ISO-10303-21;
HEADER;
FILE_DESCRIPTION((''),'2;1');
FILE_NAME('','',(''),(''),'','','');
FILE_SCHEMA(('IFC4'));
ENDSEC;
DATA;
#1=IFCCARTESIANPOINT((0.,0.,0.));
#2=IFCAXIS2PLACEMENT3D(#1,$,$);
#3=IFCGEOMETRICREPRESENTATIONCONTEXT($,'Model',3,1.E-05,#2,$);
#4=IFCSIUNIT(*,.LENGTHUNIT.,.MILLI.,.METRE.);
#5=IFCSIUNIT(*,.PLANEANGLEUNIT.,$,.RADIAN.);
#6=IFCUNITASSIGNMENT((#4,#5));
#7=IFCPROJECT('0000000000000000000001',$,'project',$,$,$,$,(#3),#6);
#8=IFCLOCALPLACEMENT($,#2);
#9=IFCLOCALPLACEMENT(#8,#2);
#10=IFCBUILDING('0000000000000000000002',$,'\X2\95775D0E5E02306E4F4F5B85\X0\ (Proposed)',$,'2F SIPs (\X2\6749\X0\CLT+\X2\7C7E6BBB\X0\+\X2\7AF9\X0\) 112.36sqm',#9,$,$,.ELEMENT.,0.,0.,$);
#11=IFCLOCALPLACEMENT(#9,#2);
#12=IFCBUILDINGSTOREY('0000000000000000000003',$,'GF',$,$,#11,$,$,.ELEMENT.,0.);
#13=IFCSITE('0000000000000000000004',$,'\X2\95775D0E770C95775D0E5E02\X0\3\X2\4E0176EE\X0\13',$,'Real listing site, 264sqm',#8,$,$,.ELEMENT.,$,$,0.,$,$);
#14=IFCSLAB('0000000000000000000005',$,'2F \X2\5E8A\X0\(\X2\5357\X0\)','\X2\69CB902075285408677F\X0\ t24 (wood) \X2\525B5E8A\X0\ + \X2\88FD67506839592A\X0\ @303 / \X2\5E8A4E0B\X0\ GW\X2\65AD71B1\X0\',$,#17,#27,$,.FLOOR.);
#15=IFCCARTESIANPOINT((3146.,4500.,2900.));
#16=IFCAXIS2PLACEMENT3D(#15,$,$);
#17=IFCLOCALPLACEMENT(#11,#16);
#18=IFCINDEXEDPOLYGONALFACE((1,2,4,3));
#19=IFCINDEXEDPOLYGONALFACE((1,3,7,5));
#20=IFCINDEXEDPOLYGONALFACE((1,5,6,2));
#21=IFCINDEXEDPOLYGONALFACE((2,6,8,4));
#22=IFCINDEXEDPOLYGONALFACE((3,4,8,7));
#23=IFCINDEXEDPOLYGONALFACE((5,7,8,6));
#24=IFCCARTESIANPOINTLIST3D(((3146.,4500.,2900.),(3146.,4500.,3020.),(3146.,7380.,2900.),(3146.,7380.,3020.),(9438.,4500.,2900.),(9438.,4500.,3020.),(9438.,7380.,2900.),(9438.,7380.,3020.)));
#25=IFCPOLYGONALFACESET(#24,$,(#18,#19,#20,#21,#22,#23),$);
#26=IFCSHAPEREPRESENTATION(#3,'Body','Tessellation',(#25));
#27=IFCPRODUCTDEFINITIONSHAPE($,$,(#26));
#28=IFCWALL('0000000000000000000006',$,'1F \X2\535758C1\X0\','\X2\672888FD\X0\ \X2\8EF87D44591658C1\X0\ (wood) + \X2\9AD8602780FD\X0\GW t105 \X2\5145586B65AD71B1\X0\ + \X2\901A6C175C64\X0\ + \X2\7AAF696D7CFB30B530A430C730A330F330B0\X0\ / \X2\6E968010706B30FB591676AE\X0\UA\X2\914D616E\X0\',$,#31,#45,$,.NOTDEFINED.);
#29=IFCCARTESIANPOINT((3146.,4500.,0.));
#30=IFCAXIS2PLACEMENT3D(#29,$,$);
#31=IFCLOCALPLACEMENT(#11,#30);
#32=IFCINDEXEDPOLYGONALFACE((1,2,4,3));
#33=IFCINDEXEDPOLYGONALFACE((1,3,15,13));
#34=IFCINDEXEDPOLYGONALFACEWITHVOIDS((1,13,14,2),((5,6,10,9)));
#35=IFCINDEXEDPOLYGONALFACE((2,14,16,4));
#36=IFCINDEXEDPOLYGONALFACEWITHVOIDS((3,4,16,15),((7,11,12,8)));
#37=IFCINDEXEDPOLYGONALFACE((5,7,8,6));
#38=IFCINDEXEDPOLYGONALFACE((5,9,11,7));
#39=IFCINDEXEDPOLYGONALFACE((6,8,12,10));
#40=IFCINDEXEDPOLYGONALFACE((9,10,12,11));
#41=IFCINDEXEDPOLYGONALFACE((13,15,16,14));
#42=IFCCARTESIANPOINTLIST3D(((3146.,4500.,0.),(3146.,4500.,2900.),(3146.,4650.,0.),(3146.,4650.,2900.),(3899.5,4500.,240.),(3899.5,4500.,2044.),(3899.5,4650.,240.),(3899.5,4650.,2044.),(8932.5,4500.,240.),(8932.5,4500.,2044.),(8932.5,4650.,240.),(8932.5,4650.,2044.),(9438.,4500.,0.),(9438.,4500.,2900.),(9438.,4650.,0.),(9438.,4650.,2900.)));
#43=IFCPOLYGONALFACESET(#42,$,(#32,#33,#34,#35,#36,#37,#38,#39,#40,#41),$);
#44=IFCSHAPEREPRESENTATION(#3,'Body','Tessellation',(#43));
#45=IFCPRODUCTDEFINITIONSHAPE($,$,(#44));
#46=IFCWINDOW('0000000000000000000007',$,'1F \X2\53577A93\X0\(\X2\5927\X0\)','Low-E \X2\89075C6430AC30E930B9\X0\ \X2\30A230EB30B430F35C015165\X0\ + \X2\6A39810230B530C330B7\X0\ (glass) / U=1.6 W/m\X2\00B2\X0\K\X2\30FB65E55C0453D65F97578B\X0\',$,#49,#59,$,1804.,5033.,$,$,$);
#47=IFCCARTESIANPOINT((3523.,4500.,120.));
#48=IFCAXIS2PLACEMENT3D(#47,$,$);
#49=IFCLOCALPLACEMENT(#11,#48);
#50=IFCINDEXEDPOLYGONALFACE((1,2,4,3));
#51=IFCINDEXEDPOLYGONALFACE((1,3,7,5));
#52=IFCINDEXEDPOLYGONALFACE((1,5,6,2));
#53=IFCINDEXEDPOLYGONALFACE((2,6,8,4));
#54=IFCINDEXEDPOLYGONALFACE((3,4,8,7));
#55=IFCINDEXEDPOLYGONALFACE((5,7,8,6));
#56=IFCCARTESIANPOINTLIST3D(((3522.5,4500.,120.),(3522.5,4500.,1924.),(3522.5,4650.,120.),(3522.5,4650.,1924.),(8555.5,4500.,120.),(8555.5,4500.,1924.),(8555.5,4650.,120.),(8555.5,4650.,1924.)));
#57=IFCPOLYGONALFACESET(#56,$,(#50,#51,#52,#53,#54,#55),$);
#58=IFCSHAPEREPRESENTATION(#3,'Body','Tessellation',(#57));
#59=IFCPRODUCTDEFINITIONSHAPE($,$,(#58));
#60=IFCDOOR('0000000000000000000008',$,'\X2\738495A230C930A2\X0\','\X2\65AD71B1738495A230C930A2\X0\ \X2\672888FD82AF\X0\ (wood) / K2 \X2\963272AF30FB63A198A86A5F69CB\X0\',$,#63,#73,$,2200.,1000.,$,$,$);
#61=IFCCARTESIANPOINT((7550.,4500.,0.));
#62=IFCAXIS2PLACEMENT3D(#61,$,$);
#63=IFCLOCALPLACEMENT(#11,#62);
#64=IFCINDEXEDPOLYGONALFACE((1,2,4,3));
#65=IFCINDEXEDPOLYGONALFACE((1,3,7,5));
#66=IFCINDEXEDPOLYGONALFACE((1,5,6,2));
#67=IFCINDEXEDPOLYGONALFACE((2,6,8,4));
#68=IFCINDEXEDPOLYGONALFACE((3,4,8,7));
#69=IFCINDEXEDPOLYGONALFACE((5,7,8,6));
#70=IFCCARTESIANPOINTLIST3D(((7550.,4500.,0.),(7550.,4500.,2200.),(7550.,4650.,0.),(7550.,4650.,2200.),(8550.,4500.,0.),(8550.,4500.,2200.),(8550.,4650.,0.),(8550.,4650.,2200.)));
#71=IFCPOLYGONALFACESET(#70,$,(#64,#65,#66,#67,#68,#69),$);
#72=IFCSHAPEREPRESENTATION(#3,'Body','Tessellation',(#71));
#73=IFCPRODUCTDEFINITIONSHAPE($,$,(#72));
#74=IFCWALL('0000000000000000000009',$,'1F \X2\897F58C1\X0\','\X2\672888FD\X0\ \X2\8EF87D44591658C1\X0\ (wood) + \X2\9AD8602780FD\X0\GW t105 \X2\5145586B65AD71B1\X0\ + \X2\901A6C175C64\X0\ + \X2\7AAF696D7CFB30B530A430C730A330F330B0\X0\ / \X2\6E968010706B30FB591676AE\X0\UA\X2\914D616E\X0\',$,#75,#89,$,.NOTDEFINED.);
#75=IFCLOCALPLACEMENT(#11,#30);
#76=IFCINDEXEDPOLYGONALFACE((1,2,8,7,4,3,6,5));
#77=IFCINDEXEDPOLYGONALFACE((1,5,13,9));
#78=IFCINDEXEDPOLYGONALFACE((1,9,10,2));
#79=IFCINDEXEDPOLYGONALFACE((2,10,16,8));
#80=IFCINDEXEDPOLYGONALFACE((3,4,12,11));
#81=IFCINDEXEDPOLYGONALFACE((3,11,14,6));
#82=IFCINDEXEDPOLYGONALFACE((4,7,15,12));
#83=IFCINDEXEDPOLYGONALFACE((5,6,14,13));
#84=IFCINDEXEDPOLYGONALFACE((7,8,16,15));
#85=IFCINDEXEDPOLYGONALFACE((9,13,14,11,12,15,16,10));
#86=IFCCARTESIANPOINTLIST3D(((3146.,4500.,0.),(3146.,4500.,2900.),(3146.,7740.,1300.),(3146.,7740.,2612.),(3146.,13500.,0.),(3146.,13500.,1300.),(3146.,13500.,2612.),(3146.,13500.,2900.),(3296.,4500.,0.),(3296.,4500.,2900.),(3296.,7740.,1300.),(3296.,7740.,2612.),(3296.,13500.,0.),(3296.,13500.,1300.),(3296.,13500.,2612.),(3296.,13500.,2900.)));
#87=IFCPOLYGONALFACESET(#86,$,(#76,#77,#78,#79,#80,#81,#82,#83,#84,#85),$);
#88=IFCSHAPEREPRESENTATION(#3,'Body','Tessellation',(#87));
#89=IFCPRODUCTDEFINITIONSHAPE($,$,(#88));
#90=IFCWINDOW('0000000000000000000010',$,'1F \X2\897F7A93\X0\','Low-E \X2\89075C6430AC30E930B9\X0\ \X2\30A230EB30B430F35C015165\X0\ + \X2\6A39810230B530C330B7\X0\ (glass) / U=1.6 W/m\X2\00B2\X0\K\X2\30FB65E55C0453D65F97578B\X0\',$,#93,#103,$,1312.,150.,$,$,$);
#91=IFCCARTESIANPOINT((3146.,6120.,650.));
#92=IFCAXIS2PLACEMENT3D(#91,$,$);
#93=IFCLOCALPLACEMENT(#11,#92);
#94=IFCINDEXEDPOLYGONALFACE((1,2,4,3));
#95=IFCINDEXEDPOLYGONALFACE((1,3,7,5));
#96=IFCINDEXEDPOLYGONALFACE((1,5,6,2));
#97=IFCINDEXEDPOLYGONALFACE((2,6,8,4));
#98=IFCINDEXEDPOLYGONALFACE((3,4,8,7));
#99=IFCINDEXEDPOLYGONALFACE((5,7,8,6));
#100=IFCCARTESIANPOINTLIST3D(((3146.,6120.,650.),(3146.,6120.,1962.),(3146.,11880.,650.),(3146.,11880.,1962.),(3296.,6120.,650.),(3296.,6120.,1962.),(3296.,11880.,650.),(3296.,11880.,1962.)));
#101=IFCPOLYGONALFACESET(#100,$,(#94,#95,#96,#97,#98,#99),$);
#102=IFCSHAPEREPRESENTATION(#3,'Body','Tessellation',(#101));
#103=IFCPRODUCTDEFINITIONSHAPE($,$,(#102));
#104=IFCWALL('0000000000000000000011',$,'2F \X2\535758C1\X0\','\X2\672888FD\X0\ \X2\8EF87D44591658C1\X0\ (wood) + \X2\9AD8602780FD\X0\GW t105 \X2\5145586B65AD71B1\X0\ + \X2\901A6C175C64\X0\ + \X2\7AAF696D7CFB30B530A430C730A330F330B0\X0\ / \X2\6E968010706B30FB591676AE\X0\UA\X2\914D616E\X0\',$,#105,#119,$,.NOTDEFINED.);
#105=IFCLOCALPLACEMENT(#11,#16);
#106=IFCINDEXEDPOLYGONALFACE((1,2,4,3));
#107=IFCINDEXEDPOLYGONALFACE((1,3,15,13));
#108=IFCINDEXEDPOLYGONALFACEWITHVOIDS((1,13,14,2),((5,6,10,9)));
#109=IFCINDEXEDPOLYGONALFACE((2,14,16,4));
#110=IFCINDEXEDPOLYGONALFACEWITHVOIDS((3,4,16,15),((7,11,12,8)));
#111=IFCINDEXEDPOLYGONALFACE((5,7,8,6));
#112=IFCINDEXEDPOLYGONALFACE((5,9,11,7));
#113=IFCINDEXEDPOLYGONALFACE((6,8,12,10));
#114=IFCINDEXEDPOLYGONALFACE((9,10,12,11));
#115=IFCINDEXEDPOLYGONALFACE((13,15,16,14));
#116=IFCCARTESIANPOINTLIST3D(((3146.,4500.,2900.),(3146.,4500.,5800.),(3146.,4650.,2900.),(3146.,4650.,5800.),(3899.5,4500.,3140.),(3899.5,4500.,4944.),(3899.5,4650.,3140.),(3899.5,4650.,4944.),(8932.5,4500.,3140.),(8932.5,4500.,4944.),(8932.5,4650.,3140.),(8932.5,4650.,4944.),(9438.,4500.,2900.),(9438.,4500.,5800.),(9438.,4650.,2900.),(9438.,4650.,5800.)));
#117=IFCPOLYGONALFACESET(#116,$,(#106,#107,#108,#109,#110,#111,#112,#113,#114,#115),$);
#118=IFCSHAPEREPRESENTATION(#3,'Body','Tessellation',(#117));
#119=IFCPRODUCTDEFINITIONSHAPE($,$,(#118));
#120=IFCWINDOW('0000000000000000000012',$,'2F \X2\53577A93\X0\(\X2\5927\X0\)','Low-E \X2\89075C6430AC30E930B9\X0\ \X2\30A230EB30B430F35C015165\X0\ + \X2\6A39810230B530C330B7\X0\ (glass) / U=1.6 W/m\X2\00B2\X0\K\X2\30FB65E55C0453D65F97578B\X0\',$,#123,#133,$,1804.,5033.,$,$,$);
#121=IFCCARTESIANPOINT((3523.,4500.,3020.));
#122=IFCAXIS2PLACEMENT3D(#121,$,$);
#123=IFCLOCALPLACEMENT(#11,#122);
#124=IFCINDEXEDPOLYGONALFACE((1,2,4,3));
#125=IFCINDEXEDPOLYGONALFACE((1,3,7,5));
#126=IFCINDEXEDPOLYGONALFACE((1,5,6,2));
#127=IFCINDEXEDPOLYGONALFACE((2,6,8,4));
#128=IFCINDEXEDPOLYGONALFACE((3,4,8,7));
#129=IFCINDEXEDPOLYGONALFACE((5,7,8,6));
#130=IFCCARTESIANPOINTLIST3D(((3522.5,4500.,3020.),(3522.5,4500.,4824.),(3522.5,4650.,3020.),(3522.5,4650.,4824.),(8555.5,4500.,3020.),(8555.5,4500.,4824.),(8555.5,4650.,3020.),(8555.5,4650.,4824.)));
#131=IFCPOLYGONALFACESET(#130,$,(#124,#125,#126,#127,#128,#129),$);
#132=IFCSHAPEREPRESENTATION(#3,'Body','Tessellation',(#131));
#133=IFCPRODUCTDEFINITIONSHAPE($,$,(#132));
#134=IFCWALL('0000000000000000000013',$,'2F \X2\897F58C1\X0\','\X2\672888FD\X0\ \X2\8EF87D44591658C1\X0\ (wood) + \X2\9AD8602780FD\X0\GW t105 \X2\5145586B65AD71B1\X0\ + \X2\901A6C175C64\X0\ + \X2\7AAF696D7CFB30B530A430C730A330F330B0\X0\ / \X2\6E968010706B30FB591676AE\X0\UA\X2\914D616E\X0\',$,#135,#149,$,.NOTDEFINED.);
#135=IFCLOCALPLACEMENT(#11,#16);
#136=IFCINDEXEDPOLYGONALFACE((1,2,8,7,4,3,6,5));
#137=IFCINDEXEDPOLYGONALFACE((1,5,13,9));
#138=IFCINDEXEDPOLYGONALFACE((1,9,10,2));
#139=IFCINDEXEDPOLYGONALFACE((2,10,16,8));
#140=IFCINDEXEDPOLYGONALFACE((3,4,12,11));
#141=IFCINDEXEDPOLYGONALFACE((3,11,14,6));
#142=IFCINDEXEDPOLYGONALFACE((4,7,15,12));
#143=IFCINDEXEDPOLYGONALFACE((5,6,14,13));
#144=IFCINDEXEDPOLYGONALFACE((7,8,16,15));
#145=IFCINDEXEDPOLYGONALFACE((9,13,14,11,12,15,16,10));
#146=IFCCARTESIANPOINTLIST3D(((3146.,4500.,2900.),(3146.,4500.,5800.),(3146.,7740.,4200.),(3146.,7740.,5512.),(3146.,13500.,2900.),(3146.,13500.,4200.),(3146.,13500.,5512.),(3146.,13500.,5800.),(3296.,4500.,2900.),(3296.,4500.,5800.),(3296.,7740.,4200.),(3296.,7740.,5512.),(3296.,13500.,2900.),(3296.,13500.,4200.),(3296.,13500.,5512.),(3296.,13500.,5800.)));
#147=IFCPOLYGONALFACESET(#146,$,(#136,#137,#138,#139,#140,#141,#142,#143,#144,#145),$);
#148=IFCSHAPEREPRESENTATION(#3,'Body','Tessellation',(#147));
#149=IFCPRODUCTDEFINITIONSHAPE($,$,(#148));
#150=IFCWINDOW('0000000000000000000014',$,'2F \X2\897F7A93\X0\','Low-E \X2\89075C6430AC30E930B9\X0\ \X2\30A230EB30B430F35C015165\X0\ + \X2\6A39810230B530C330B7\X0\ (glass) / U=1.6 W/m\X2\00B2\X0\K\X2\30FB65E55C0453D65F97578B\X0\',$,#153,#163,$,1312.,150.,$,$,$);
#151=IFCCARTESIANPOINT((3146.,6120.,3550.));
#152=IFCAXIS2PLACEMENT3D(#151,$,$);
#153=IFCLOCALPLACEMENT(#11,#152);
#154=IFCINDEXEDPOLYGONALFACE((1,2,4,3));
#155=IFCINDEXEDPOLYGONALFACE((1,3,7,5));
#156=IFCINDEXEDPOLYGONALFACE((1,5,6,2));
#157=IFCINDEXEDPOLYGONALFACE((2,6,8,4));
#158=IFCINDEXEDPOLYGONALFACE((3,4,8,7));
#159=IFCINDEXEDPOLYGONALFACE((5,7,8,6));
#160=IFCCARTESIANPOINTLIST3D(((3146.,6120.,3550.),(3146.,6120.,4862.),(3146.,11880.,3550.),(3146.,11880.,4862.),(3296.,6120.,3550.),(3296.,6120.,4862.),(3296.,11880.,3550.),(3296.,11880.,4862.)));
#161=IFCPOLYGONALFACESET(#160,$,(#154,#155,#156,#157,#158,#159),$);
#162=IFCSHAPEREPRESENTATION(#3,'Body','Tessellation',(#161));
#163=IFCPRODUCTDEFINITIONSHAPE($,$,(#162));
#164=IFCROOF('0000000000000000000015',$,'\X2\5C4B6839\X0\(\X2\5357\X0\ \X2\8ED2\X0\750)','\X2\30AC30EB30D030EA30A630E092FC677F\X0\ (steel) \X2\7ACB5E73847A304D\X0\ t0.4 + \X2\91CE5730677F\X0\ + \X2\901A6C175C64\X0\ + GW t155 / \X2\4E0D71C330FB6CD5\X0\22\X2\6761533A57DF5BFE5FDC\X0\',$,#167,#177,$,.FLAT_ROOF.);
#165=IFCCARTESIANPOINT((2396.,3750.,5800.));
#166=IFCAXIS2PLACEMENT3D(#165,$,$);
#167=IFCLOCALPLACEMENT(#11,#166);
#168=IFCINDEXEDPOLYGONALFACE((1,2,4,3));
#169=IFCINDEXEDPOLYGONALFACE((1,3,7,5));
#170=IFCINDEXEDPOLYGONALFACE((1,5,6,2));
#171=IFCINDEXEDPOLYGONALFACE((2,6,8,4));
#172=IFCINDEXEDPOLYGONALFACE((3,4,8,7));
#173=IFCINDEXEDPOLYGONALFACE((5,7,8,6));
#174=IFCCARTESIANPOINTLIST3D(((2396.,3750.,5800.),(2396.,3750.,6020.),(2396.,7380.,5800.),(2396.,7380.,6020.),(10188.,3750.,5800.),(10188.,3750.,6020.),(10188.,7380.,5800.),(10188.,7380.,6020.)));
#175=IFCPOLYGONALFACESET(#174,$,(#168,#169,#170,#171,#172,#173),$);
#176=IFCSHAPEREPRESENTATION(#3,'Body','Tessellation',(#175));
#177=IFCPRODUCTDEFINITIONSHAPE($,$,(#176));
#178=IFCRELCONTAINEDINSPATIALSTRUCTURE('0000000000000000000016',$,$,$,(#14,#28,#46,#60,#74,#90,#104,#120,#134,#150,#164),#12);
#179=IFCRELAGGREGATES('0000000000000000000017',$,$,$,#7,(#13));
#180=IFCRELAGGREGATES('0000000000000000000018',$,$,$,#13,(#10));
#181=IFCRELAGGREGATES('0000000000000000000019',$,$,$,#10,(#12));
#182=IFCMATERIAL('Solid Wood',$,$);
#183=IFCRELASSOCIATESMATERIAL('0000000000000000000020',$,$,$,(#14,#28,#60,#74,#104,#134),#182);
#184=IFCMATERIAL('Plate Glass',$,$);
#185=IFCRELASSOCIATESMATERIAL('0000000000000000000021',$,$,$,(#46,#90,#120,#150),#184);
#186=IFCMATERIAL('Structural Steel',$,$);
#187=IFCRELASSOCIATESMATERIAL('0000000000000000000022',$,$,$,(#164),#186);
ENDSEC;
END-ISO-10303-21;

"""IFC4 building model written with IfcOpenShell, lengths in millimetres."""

from ifc_helpers import new_model, si_unit, frame, frame_2d, origin, place, context, project, spatial, rectangle, extrude, material, element, fill, save


model = new_model("IFC4")

# Units and contexts
model_context = context("Model", 3, precision=1e-05, world=origin())
ifc_project = project(units=[si_unit("LENGTHUNIT", "METRE", prefix="MILLI"), si_unit("PLANEANGLEUNIT", "RADIAN")], contexts=[model_context])

# Site, building, storey
site_placement = place(None, origin())
site = spatial("IfcSite", under=ifc_project, at=site_placement, Name="長崎県長崎市3丁目13", ObjectType="Real listing site, 264sqm", CompositionType="ELEMENT", RefElevation=0.0)
building_placement = place(site_placement, origin())
building = spatial("IfcBuilding", under=site, at=building_placement, Name="長崎市の住宅 (Proposed)", ObjectType="2F SIPs (杉CLT+籾殻+竹) 112.36sqm", CompositionType="ELEMENT", ElevationOfRefHeight=0.0, ElevationOfTerrain=0.0)
storey_placement = place(building_placement, origin())
storey = spatial("IfcBuildingStorey", under=building, at=storey_placement, Name="GF", CompositionType="ELEMENT", Elevation=0.0)

# Slab
ifc_material_1 = material(Name="Solid Wood")
slab_1_placement = place(storey_placement, frame((3146.0, 4500.0, 2900.0)))
element("IfcSlab", 1, at=slab_1_placement, inside=storey, material=ifc_material_1, Name="2F 床(南)", Description="構造用合板 t24 (wood) 剛床 + 製材根太 @303 / 床下 GW断熱", PredefinedType="FLOOR", context=model_context, shape_type="SweptSolid", body=[
    extrude(rectangle(XDim=6292.0, YDim=2880.0, at=frame_2d((3146.0, 1440.0))), frame((3146.0, 4500.0, 2900.0)), (0.0, 0.0, 1.0), 120.0),
])

# Wall, openings, window, door
wall_1_placement = place(storey_placement, frame((3146.0, 4500.0, 0.0)))
wall_1 = element("IfcWall", 2, at=wall_1_placement, inside=storey, material=ifc_material_1, Name="1F 南壁", Description="木製 軸組外壁 (wood) + 高性能GW t105 充填断熱 + 通気層 + 窯業系サイディング / 準耐火・外皮UA配慮", PredefinedType="NOTDEFINED", context=model_context, shape_type="SweptSolid", body=[
    extrude(rectangle(XDim=6292.0, YDim=150.0, at=frame_2d((3146.0, 75.0))), frame((3146.0, 4500.0, 0.0)), (0.0, 0.0, 1.0), 2900.0),
])
opening_1_placement = place(storey_placement, frame((3523.0, 4500.0, 120.0)))
opening_1 = element("IfcOpeningElement", 3, at=opening_1_placement, cuts=wall_1, PredefinedType="NOTDEFINED", context=model_context, shape_type="SweptSolid", body=[
    extrude(rectangle(XDim=5033.0, YDim=150.0, at=frame_2d((2516.0, 75.0))), frame((3523.0, 4500.0, 120.0)), (0.0, 0.0, 1.0), 1804.0),
])
opening_2_placement = place(storey_placement, frame((7550.0, 4500.0, 0.0)))
opening_2 = element("IfcOpeningElement", 4, at=opening_2_placement, cuts=wall_1, PredefinedType="NOTDEFINED", context=model_context, shape_type="SweptSolid", body=[
    extrude(rectangle(XDim=1000.0, YDim=150.0, at=frame_2d((500.0, 75.0))), frame((7550.0, 4500.0, 0.0)), (0.0, 0.0, 1.0), 2200.0),
])
ifc_material_2 = material(Name="Plate Glass")
window_1_placement = place(storey_placement, frame((3523.0, 4500.0, 120.0)))
window_1 = element("IfcWindow", 5, at=window_1_placement, inside=storey, material=ifc_material_2, Name="1F 南窓(大)", Description="Low-E 複層ガラス アルゴン封入 + 樹脂サッシ (glass) / U=1.6 W/m²K・日射取得型", OverallHeight=1804.0, OverallWidth=5033.0, context=model_context, shape_type="SweptSolid", body=[
    extrude(rectangle(XDim=5033.0, YDim=150.0, at=frame_2d((2516.0, 75.0))), frame((3523.0, 4500.0, 120.0)), (0.0, 0.0, 1.0), 1804.0),
])
fill(opening_1, window_1)
door_placement = place(storey_placement, frame((7550.0, 4500.0, 0.0)))
door = element("IfcDoor", 6, at=door_placement, inside=storey, material=ifc_material_1, Name="玄関ドア", Description="断熱玄関ドア 木製芯 (wood) / K2 防犯・採風機構", OverallHeight=2200.0, OverallWidth=1000.0, context=model_context, shape_type="SweptSolid", body=[
    extrude(rectangle(XDim=1000.0, YDim=150.0, at=frame_2d((500.0, 75.0))), frame((7550.0, 4500.0, 0.0)), (0.0, 0.0, 1.0), 2200.0),
])
fill(opening_2, door)

# Walls, openings, windows
wall_2_placement = place(storey_placement, frame((3146.0, 4500.0, 0.0)))
wall_2 = element("IfcWall", 7, at=wall_2_placement, inside=storey, material=ifc_material_1, Name="1F 西壁", Description="木製 軸組外壁 (wood) + 高性能GW t105 充填断熱 + 通気層 + 窯業系サイディング / 準耐火・外皮UA配慮", PredefinedType="NOTDEFINED", context=model_context, shape_type="SweptSolid", body=[
    extrude(rectangle(XDim=150.0, YDim=9000.0, at=frame_2d((75.0, 4500.0))), frame((3146.0, 4500.0, 0.0)), (0.0, 0.0, 1.0), 2900.0),
])
opening_3_placement = place(storey_placement, frame((3146.0, 6120.0, 650.0)))
opening_3 = element("IfcOpeningElement", 8, at=opening_3_placement, cuts=wall_2, PredefinedType="NOTDEFINED", context=model_context, shape_type="SweptSolid", body=[
    extrude(rectangle(XDim=150.0, YDim=5760.0, at=frame_2d((75.0, 2880.0))), frame((3146.0, 6120.0, 650.0)), (0.0, 0.0, 1.0), 1312.0),
])
window_2_placement = place(storey_placement, frame((3146.0, 6120.0, 650.0)))
window_2 = element("IfcWindow", 9, at=window_2_placement, inside=storey, material=ifc_material_2, Name="1F 西窓", Description="Low-E 複層ガラス アルゴン封入 + 樹脂サッシ (glass) / U=1.6 W/m²K・日射取得型", OverallHeight=1312.0, OverallWidth=150.0, context=model_context, shape_type="SweptSolid", body=[
    extrude(rectangle(XDim=150.0, YDim=5760.0, at=frame_2d((75.0, 2880.0))), frame((3146.0, 6120.0, 650.0)), (0.0, 0.0, 1.0), 1312.0),
])
fill(opening_3, window_2)
wall_3_placement = place(storey_placement, frame((3146.0, 4500.0, 2900.0)))
wall_3 = element("IfcWall", 10, at=wall_3_placement, inside=storey, material=ifc_material_1, Name="2F 南壁", Description="木製 軸組外壁 (wood) + 高性能GW t105 充填断熱 + 通気層 + 窯業系サイディング / 準耐火・外皮UA配慮", PredefinedType="NOTDEFINED", context=model_context, shape_type="SweptSolid", body=[
    extrude(rectangle(XDim=6292.0, YDim=150.0, at=frame_2d((3146.0, 75.0))), frame((3146.0, 4500.0, 2900.0)), (0.0, 0.0, 1.0), 2900.0),
])
opening_4_placement = place(storey_placement, frame((3523.0, 4500.0, 3020.0)))
opening_4 = element("IfcOpeningElement", 11, at=opening_4_placement, cuts=wall_3, PredefinedType="NOTDEFINED", context=model_context, shape_type="SweptSolid", body=[
    extrude(rectangle(XDim=5033.0, YDim=150.0, at=frame_2d((2516.0, 75.0))), frame((3523.0, 4500.0, 3020.0)), (0.0, 0.0, 1.0), 1804.0),
])
window_3_placement = place(storey_placement, frame((3523.0, 4500.0, 3020.0)))
window_3 = element("IfcWindow", 12, at=window_3_placement, inside=storey, material=ifc_material_2, Name="2F 南窓(大)", Description="Low-E 複層ガラス アルゴン封入 + 樹脂サッシ (glass) / U=1.6 W/m²K・日射取得型", OverallHeight=1804.0, OverallWidth=5033.0, context=model_context, shape_type="SweptSolid", body=[
    extrude(rectangle(XDim=5033.0, YDim=150.0, at=frame_2d((2516.0, 75.0))), frame((3523.0, 4500.0, 3020.0)), (0.0, 0.0, 1.0), 1804.0),
])
fill(opening_4, window_3)
wall_4_placement = place(storey_placement, frame((3146.0, 4500.0, 2900.0)))
wall_4 = element("IfcWall", 13, at=wall_4_placement, inside=storey, material=ifc_material_1, Name="2F 西壁", Description="木製 軸組外壁 (wood) + 高性能GW t105 充填断熱 + 通気層 + 窯業系サイディング / 準耐火・外皮UA配慮", PredefinedType="NOTDEFINED", context=model_context, shape_type="SweptSolid", body=[
    extrude(rectangle(XDim=150.0, YDim=9000.0, at=frame_2d((75.0, 4500.0))), frame((3146.0, 4500.0, 2900.0)), (0.0, 0.0, 1.0), 2900.0),
])
opening_5_placement = place(storey_placement, frame((3146.0, 6120.0, 3550.0)))
opening_5 = element("IfcOpeningElement", 14, at=opening_5_placement, cuts=wall_4, PredefinedType="NOTDEFINED", context=model_context, shape_type="SweptSolid", body=[
    extrude(rectangle(XDim=150.0, YDim=5760.0, at=frame_2d((75.0, 2880.0))), frame((3146.0, 6120.0, 3550.0)), (0.0, 0.0, 1.0), 1312.0),
])
window_4_placement = place(storey_placement, frame((3146.0, 6120.0, 3550.0)))
window_4 = element("IfcWindow", 15, at=window_4_placement, inside=storey, material=ifc_material_2, Name="2F 西窓", Description="Low-E 複層ガラス アルゴン封入 + 樹脂サッシ (glass) / U=1.6 W/m²K・日射取得型", OverallHeight=1312.0, OverallWidth=150.0, context=model_context, shape_type="SweptSolid", body=[
    extrude(rectangle(XDim=150.0, YDim=5760.0, at=frame_2d((75.0, 2880.0))), frame((3146.0, 6120.0, 3550.0)), (0.0, 0.0, 1.0), 1312.0),
])
fill(opening_5, window_4)

# Roof
ifc_material_3 = material(Name="Structural Steel")
roof_1_placement = place(storey_placement, frame((2396.0, 3750.0, 5800.0)))
element("IfcRoof", 16, at=roof_1_placement, inside=storey, material=ifc_material_3, Name="屋根(南 軒750)", Description="ガルバリウム鋼板 (steel) 立平葺き t0.4 + 野地板 + 通気層 + GW t155 / 不燃・法22条区域対応", PredefinedType="FLAT_ROOF", context=model_context, shape_type="SweptSolid", body=[
    extrude(rectangle(XDim=7792.0, YDim=3630.0, at=frame_2d((3896.0, 1815.0))), frame((2396.0, 3750.0, 5800.0)), (0.0, 0.0, 1.0), 220.0),
])

save(model, "model.ifc")
